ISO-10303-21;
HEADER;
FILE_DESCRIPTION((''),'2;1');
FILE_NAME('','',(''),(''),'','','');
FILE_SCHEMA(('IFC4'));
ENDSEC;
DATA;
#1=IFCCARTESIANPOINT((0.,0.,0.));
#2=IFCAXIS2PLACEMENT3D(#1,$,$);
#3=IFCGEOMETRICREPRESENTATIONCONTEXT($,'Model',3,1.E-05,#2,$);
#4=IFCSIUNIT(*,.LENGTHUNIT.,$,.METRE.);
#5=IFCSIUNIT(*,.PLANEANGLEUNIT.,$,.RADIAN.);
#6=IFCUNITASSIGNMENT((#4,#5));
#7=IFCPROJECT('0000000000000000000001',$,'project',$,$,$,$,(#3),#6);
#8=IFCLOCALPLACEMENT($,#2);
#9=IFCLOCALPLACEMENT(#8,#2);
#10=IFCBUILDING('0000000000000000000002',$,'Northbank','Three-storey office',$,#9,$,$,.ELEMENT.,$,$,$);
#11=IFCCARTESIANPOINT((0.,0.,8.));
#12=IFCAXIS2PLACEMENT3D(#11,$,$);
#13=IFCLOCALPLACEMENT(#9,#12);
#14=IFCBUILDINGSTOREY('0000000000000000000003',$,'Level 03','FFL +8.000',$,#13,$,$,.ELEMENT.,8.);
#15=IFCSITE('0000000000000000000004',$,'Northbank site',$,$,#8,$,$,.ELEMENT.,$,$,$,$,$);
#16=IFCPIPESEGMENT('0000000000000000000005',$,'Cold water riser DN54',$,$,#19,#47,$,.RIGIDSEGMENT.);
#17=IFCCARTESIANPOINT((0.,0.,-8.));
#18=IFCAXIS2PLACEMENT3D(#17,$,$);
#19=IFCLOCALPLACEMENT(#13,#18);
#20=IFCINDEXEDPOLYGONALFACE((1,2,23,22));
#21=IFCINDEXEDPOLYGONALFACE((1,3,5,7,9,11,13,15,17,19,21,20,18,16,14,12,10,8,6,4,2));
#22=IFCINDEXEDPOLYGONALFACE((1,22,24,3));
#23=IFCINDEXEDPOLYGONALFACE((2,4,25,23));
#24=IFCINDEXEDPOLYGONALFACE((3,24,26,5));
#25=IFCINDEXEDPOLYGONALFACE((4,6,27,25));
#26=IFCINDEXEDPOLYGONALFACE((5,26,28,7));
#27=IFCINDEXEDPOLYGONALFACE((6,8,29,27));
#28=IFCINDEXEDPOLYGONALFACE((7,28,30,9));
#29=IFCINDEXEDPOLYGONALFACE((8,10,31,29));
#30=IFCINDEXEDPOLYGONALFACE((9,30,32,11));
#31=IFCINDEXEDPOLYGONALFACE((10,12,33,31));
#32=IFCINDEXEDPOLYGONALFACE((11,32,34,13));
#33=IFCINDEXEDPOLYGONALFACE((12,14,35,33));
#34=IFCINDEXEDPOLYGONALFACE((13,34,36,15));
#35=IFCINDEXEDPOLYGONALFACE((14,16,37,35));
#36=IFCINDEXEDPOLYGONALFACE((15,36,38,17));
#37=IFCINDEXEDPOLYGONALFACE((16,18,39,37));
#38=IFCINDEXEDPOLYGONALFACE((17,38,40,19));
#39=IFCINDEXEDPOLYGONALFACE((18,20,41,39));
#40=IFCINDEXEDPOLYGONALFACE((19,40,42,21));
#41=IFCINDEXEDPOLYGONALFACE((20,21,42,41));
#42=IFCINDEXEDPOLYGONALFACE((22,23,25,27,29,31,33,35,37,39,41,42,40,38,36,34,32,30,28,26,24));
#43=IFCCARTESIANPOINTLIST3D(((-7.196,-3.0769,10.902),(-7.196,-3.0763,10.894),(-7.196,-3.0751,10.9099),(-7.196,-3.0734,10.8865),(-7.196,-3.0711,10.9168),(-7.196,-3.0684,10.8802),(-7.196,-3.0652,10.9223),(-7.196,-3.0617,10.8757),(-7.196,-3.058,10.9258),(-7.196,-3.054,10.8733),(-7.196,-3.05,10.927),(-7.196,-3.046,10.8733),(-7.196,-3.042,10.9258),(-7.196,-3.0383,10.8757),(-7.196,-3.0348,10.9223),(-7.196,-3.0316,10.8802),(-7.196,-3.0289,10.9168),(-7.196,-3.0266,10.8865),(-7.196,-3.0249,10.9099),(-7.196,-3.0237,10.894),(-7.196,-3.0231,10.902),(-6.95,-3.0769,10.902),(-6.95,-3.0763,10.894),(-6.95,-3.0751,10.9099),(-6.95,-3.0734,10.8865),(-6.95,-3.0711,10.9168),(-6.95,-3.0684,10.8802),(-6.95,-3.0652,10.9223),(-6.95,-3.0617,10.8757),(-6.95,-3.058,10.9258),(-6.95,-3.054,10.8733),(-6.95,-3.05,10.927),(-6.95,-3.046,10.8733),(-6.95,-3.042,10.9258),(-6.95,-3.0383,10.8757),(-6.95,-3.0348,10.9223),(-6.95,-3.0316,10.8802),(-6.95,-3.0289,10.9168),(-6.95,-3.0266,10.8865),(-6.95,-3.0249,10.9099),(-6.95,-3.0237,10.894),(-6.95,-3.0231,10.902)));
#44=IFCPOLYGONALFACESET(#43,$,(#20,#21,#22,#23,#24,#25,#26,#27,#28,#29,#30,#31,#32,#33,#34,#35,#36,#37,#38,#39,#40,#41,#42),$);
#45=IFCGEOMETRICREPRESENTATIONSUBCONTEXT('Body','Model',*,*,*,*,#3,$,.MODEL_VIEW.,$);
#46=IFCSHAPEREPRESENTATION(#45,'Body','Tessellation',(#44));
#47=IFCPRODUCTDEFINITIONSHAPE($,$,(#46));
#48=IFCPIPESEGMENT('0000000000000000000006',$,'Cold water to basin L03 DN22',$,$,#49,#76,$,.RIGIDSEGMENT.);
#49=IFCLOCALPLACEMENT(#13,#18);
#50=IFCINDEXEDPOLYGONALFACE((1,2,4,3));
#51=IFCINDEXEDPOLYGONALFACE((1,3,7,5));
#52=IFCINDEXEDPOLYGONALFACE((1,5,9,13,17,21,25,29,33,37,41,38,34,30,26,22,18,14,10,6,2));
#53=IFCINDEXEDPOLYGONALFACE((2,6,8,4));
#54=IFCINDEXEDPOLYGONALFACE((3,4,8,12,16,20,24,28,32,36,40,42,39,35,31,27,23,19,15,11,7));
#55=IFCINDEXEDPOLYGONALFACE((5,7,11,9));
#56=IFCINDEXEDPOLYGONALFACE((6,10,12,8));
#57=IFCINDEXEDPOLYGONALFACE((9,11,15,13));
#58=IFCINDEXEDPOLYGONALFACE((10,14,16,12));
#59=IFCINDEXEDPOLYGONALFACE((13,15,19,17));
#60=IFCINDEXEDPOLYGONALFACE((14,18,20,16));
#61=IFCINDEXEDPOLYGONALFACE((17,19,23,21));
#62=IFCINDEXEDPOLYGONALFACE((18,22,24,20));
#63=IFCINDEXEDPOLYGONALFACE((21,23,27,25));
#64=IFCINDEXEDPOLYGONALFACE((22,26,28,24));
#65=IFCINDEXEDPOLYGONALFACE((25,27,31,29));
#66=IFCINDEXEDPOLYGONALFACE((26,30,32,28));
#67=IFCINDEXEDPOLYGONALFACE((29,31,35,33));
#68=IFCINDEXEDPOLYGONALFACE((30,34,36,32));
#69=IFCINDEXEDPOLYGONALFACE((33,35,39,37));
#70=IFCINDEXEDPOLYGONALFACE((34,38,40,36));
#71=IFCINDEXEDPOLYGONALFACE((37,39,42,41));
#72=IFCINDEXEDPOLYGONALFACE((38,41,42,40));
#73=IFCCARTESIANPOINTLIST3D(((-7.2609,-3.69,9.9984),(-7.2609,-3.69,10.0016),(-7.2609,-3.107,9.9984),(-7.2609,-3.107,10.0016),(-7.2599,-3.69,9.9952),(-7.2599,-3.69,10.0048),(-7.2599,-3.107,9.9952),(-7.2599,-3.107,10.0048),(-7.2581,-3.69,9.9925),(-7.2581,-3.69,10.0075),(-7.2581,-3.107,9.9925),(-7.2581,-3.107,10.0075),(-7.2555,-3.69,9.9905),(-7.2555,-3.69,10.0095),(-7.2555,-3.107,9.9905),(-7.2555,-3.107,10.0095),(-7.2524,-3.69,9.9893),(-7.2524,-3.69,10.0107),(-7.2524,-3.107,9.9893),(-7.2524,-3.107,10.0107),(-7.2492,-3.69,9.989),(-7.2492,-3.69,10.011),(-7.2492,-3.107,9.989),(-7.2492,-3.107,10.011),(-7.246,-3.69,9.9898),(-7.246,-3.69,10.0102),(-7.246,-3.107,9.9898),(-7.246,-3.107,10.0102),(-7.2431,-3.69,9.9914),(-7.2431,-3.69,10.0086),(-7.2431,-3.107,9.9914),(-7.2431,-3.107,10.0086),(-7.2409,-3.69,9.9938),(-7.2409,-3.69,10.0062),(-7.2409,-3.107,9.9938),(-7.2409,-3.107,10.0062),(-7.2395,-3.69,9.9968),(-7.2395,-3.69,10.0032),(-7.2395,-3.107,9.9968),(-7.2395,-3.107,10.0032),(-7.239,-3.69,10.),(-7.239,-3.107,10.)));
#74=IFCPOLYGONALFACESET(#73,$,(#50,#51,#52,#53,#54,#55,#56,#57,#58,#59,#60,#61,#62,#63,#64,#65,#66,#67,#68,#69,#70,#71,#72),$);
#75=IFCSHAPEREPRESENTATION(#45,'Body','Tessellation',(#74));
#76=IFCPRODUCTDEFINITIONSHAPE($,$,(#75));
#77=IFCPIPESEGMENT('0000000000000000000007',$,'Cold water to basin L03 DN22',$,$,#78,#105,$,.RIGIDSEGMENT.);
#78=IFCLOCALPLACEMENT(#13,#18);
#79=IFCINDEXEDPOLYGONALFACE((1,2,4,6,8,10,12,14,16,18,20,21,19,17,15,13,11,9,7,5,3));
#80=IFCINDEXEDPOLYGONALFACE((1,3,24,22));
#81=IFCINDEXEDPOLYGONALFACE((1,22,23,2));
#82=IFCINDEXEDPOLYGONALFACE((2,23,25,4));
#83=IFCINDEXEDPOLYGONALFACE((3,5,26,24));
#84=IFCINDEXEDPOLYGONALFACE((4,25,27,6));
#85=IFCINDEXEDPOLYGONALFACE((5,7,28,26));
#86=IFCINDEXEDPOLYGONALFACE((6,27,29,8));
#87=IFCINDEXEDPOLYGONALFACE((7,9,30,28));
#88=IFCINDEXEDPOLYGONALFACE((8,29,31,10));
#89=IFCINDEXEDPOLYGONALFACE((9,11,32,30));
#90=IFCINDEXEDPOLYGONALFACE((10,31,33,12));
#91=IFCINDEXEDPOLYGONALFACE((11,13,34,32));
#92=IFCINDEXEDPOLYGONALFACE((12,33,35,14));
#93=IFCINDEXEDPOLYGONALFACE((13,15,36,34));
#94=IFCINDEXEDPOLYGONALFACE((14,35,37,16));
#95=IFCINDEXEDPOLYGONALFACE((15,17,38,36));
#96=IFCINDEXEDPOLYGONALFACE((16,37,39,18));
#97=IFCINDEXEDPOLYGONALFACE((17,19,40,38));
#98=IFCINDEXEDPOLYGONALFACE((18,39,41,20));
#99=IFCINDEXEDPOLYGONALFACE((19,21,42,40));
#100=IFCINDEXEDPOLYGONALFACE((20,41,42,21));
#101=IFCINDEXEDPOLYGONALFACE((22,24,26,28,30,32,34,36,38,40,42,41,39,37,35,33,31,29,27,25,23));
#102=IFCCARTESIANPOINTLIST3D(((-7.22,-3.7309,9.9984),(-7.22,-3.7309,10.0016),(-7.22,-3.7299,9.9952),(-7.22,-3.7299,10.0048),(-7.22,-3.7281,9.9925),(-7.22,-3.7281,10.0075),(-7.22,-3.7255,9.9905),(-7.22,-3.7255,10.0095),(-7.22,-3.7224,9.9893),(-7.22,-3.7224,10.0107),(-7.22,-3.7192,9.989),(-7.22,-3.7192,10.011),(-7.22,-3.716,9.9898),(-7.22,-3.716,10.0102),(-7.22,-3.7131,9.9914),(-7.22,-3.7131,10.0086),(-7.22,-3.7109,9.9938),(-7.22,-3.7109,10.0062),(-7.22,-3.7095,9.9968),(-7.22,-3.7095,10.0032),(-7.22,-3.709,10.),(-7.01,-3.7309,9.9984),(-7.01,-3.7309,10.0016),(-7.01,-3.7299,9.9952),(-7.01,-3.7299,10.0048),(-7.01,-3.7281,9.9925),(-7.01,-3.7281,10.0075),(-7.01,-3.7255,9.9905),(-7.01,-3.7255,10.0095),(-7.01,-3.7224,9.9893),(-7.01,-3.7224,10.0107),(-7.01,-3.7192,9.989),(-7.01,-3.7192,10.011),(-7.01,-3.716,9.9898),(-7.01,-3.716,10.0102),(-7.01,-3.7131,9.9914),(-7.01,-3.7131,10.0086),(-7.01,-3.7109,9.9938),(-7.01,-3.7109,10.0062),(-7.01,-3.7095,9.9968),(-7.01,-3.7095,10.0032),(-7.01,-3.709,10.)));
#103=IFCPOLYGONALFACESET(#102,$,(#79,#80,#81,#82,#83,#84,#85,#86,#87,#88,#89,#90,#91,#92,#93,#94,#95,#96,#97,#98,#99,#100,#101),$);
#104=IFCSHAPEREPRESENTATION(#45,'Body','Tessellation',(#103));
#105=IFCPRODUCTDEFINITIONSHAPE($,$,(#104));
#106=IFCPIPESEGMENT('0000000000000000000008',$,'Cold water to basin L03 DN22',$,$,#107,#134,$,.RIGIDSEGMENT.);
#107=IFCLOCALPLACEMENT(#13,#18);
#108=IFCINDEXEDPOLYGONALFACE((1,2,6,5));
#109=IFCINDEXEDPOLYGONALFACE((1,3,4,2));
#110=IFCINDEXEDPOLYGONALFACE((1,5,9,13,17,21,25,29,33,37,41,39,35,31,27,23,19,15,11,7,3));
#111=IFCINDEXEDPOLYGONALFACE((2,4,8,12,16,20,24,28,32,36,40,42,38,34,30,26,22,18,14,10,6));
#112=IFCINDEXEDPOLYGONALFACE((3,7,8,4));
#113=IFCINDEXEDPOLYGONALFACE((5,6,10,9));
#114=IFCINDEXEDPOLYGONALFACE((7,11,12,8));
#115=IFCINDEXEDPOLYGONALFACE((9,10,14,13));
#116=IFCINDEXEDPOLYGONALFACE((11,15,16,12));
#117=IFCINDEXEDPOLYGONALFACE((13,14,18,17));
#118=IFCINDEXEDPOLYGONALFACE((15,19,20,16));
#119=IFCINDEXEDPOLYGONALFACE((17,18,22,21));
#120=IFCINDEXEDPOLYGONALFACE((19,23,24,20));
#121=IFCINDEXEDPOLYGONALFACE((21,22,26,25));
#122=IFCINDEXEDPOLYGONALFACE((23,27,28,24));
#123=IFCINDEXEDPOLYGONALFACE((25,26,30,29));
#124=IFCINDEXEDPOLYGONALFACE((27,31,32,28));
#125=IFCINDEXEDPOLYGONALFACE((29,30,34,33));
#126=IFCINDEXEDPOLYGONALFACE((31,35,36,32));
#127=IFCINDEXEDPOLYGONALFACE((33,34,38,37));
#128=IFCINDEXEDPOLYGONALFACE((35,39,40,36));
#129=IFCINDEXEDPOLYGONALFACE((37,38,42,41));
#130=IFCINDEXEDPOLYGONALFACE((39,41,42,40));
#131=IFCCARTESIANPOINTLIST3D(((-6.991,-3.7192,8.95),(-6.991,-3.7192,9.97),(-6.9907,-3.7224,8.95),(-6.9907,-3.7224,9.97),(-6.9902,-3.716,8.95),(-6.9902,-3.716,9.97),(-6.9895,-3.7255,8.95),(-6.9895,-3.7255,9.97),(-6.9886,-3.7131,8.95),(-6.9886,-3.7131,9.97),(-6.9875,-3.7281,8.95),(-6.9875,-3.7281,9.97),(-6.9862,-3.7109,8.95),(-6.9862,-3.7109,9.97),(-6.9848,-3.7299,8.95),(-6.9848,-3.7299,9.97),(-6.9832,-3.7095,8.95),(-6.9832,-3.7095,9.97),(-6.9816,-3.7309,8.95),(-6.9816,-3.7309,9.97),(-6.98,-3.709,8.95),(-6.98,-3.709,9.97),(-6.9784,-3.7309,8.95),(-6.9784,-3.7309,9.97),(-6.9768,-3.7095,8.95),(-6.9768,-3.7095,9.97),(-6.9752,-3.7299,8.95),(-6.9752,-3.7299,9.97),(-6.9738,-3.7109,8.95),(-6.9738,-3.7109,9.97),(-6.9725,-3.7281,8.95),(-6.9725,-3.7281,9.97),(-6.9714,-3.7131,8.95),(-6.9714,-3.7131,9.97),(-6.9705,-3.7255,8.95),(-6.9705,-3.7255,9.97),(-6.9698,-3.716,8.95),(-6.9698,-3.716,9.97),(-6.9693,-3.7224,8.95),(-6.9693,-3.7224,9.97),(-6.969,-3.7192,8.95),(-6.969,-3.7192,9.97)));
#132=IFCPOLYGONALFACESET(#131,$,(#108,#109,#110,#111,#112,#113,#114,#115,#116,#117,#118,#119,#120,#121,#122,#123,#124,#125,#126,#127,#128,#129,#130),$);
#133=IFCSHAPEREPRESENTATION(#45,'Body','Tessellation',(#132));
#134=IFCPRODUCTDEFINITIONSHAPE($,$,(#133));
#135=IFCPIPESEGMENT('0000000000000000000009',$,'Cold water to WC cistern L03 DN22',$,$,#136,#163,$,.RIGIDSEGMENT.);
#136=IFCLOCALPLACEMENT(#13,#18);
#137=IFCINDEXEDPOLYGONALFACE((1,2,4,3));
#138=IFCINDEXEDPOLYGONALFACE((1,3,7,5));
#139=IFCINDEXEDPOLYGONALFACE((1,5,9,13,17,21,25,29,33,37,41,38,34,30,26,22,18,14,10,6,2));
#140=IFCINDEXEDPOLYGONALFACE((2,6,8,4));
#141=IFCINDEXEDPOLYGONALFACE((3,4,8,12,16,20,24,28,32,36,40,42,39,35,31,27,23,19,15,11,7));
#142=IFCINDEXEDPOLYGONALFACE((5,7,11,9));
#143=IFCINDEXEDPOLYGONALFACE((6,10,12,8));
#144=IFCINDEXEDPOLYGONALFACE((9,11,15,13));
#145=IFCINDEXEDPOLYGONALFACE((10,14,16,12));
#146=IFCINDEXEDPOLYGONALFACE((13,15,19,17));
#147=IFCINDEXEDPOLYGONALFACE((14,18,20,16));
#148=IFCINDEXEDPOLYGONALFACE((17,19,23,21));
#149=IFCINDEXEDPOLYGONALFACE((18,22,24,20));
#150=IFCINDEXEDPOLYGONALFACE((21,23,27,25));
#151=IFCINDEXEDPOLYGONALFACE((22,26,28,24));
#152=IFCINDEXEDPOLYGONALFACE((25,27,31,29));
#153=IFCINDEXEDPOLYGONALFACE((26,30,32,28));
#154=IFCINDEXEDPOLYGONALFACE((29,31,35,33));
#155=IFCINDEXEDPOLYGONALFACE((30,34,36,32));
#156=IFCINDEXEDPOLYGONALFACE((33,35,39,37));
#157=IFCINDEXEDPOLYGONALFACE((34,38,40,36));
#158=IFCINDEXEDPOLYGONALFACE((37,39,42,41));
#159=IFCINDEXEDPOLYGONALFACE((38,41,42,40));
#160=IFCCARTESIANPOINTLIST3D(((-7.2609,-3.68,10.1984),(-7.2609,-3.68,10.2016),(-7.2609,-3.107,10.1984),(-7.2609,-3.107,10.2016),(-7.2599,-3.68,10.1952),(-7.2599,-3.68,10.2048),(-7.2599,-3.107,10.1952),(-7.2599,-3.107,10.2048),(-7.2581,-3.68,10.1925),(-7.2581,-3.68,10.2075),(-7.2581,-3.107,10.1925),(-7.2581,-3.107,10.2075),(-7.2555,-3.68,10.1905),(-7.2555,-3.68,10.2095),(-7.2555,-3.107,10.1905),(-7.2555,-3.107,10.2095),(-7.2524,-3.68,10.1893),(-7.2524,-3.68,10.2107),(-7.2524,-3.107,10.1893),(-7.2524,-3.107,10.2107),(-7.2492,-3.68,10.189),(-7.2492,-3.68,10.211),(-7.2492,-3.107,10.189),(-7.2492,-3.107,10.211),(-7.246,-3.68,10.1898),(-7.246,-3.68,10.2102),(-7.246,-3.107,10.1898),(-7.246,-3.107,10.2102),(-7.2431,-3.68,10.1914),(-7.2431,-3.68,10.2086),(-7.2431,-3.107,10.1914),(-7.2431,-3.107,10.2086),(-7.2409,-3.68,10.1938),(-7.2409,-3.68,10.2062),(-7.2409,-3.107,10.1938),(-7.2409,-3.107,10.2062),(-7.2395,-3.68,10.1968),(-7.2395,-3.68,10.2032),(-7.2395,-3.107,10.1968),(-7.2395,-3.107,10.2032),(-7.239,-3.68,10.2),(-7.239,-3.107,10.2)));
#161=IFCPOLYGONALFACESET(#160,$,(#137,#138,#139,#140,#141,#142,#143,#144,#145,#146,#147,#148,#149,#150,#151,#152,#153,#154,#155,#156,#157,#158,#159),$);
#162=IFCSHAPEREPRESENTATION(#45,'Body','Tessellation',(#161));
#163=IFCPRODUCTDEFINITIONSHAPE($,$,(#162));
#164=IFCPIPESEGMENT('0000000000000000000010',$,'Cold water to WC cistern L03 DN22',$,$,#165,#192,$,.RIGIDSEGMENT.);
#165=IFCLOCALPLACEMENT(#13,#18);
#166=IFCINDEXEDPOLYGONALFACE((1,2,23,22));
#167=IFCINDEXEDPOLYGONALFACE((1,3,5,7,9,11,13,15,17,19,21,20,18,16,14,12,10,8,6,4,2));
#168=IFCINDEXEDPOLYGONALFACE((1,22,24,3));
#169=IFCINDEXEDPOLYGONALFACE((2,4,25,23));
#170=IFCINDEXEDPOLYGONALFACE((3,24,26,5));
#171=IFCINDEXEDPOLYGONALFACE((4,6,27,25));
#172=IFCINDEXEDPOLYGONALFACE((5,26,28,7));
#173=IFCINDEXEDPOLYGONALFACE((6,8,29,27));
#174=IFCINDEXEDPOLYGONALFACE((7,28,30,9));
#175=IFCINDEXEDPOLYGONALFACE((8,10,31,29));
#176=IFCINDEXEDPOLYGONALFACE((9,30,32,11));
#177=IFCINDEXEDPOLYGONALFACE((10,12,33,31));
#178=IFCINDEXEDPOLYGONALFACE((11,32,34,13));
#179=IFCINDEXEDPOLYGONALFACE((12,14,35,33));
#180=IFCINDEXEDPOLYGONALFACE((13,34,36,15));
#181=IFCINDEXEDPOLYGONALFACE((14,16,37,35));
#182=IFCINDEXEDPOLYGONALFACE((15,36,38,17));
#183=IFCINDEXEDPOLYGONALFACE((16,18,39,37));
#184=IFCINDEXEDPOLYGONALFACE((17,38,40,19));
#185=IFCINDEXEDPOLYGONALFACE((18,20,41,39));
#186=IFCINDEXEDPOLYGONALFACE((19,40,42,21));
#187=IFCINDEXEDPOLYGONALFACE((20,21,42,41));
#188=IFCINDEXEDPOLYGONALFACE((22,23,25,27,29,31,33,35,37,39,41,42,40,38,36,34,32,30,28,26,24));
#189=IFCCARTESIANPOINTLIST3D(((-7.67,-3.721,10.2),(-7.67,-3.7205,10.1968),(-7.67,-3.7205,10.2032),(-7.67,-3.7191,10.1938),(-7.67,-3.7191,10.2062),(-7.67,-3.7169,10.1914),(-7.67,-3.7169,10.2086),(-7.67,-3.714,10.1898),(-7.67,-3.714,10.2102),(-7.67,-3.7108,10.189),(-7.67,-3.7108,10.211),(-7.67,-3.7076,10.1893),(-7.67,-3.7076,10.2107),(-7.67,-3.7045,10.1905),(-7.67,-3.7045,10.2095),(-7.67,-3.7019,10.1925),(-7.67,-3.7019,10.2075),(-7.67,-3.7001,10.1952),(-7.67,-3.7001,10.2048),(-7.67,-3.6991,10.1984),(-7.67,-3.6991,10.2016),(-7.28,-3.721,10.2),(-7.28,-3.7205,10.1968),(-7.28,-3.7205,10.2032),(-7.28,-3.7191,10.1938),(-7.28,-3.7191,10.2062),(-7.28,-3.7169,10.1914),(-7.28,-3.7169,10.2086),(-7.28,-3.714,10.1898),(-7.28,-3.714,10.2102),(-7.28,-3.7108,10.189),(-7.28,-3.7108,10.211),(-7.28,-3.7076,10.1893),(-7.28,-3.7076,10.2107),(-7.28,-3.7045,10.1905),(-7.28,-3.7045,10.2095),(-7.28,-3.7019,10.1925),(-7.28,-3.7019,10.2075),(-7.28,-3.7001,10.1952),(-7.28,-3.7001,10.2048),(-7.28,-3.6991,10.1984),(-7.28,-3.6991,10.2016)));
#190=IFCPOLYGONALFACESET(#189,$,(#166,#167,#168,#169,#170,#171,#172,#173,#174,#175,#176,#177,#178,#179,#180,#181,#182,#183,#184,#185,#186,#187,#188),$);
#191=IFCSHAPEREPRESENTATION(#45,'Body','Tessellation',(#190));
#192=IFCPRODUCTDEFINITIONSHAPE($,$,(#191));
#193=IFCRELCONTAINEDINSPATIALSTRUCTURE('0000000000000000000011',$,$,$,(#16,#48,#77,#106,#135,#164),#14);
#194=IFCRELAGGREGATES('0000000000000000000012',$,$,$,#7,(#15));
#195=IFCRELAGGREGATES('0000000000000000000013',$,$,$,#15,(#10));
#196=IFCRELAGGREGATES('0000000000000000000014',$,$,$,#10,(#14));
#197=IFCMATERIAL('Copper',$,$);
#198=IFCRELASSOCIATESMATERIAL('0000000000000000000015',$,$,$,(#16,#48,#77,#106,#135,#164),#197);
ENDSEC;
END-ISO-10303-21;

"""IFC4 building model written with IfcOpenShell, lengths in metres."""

from ifc_helpers import new_model, si_unit, frame, origin, place, context, subcontext, project, spatial, circle, extrude, material, element, save


model = new_model("IFC4")

# Units and contexts
model_context = context("Model", 3, precision=1e-05, world=origin())
body_context = subcontext(model_context, "Body", "Model", "MODEL_VIEW")
ifc_project = project(units=[si_unit("LENGTHUNIT", "METRE"), si_unit("PLANEANGLEUNIT", "RADIAN")], contexts=[model_context])

# Site, building, storey
site_placement = place(None, origin())
site = spatial("IfcSite", under=ifc_project, at=site_placement, Name="Northbank site", CompositionType="ELEMENT")
building_placement = place(site_placement, origin())
building = spatial("IfcBuilding", under=site, at=building_placement, Name="Northbank", Description="Three-storey office", CompositionType="ELEMENT")
storey_placement = place(building_placement, frame((0.0, 0.0, 8.0)))
storey = spatial("IfcBuildingStorey", under=building, at=storey_placement, Name="Level 03", Description="FFL +8.000", CompositionType="ELEMENT", Elevation=8.0)

# Shared definitions
ifc_material_1 = material(Name="Copper")

# Pipe segments
pipe_segment_1_placement = place(storey_placement, frame((0.0, 0.0, -8.0)))
element("IfcPipeSegment", 1, at=pipe_segment_1_placement, inside=storey, material=ifc_material_1, Name="Cold water riser DN54", PredefinedType="RIGIDSEGMENT", context=body_context, shape_type="SweptSolid", body=[
    extrude(circle(Radius=0.027), frame((-7.196, -3.05, 10.9), z_axis=(1.0, 0.0, 0.0), x_axis=(0.0, 0.0, 1.0)), (0.0, 0.0, 1.0), 0.246),
])
pipe_segment_2_placement = place(storey_placement, frame((0.0, 0.0, -8.0)))
element("IfcPipeSegment", 2, at=pipe_segment_2_placement, inside=storey, material=ifc_material_1, Name="Cold water to basin L03 DN22", PredefinedType="RIGIDSEGMENT", context=body_context, shape_type="SweptSolid", body=[
    extrude(circle(Radius=0.011), frame((-7.25, -3.107, 10.0), z_axis=(0.0, -1.0, 0.0), x_axis=(1.0, 0.0, 0.0)), (0.0, 0.0, 1.0), 0.583),
])
pipe_segment_3_placement = place(storey_placement, frame((0.0, 0.0, -8.0)))
element("IfcPipeSegment", 3, at=pipe_segment_3_placement, inside=storey, material=ifc_material_1, Name="Cold water to basin L03 DN22", PredefinedType="RIGIDSEGMENT", context=body_context, shape_type="SweptSolid", body=[
    extrude(circle(Radius=0.011), frame((-7.22, -3.72, 10.0), z_axis=(1.0, 0.0, 0.0), x_axis=(0.0, 1.0, 0.0)), (0.0, 0.0, 1.0), 0.21),
])
pipe_segment_4_placement = place(storey_placement, frame((0.0, 0.0, -8.0)))
element("IfcPipeSegment", 4, at=pipe_segment_4_placement, inside=storey, material=ifc_material_1, Name="Cold water to basin L03 DN22", PredefinedType="RIGIDSEGMENT", context=body_context, shape_type="SweptSolid", body=[
    extrude(circle(Radius=0.011), frame((-6.98, -3.72, 9.97), z_axis=(0.0, 0.0, -1.0), x_axis=(0.0, 1.0, 0.0)), (0.0, 0.0, 1.0), 1.02),
])
pipe_segment_5_placement = place(storey_placement, frame((0.0, 0.0, -8.0)))
element("IfcPipeSegment", 5, at=pipe_segment_5_placement, inside=storey, material=ifc_material_1, Name="Cold water to WC cistern L03 DN22", PredefinedType="RIGIDSEGMENT", context=body_context, shape_type="SweptSolid", body=[
    extrude(circle(Radius=0.011), frame((-7.25, -3.107, 10.2), z_axis=(0.0, -1.0, 0.0), x_axis=(1.0, 0.0, 0.0)), (0.0, 0.0, 1.0), 0.573),
])
pipe_segment_6_placement = place(storey_placement, frame((0.0, 0.0, -8.0)))
element("IfcPipeSegment", 6, at=pipe_segment_6_placement, inside=storey, material=ifc_material_1, Name="Cold water to WC cistern L03 DN22", PredefinedType="RIGIDSEGMENT", context=body_context, shape_type="SweptSolid", body=[
    extrude(circle(Radius=0.011), frame((-7.28, -3.71, 10.2), z_axis=(-1.0, 0.0, 0.0), x_axis=(0.0, -1.0, 0.0)), (0.0, 0.0, 1.0), 0.39),
])

save(model, "model.ifc")
